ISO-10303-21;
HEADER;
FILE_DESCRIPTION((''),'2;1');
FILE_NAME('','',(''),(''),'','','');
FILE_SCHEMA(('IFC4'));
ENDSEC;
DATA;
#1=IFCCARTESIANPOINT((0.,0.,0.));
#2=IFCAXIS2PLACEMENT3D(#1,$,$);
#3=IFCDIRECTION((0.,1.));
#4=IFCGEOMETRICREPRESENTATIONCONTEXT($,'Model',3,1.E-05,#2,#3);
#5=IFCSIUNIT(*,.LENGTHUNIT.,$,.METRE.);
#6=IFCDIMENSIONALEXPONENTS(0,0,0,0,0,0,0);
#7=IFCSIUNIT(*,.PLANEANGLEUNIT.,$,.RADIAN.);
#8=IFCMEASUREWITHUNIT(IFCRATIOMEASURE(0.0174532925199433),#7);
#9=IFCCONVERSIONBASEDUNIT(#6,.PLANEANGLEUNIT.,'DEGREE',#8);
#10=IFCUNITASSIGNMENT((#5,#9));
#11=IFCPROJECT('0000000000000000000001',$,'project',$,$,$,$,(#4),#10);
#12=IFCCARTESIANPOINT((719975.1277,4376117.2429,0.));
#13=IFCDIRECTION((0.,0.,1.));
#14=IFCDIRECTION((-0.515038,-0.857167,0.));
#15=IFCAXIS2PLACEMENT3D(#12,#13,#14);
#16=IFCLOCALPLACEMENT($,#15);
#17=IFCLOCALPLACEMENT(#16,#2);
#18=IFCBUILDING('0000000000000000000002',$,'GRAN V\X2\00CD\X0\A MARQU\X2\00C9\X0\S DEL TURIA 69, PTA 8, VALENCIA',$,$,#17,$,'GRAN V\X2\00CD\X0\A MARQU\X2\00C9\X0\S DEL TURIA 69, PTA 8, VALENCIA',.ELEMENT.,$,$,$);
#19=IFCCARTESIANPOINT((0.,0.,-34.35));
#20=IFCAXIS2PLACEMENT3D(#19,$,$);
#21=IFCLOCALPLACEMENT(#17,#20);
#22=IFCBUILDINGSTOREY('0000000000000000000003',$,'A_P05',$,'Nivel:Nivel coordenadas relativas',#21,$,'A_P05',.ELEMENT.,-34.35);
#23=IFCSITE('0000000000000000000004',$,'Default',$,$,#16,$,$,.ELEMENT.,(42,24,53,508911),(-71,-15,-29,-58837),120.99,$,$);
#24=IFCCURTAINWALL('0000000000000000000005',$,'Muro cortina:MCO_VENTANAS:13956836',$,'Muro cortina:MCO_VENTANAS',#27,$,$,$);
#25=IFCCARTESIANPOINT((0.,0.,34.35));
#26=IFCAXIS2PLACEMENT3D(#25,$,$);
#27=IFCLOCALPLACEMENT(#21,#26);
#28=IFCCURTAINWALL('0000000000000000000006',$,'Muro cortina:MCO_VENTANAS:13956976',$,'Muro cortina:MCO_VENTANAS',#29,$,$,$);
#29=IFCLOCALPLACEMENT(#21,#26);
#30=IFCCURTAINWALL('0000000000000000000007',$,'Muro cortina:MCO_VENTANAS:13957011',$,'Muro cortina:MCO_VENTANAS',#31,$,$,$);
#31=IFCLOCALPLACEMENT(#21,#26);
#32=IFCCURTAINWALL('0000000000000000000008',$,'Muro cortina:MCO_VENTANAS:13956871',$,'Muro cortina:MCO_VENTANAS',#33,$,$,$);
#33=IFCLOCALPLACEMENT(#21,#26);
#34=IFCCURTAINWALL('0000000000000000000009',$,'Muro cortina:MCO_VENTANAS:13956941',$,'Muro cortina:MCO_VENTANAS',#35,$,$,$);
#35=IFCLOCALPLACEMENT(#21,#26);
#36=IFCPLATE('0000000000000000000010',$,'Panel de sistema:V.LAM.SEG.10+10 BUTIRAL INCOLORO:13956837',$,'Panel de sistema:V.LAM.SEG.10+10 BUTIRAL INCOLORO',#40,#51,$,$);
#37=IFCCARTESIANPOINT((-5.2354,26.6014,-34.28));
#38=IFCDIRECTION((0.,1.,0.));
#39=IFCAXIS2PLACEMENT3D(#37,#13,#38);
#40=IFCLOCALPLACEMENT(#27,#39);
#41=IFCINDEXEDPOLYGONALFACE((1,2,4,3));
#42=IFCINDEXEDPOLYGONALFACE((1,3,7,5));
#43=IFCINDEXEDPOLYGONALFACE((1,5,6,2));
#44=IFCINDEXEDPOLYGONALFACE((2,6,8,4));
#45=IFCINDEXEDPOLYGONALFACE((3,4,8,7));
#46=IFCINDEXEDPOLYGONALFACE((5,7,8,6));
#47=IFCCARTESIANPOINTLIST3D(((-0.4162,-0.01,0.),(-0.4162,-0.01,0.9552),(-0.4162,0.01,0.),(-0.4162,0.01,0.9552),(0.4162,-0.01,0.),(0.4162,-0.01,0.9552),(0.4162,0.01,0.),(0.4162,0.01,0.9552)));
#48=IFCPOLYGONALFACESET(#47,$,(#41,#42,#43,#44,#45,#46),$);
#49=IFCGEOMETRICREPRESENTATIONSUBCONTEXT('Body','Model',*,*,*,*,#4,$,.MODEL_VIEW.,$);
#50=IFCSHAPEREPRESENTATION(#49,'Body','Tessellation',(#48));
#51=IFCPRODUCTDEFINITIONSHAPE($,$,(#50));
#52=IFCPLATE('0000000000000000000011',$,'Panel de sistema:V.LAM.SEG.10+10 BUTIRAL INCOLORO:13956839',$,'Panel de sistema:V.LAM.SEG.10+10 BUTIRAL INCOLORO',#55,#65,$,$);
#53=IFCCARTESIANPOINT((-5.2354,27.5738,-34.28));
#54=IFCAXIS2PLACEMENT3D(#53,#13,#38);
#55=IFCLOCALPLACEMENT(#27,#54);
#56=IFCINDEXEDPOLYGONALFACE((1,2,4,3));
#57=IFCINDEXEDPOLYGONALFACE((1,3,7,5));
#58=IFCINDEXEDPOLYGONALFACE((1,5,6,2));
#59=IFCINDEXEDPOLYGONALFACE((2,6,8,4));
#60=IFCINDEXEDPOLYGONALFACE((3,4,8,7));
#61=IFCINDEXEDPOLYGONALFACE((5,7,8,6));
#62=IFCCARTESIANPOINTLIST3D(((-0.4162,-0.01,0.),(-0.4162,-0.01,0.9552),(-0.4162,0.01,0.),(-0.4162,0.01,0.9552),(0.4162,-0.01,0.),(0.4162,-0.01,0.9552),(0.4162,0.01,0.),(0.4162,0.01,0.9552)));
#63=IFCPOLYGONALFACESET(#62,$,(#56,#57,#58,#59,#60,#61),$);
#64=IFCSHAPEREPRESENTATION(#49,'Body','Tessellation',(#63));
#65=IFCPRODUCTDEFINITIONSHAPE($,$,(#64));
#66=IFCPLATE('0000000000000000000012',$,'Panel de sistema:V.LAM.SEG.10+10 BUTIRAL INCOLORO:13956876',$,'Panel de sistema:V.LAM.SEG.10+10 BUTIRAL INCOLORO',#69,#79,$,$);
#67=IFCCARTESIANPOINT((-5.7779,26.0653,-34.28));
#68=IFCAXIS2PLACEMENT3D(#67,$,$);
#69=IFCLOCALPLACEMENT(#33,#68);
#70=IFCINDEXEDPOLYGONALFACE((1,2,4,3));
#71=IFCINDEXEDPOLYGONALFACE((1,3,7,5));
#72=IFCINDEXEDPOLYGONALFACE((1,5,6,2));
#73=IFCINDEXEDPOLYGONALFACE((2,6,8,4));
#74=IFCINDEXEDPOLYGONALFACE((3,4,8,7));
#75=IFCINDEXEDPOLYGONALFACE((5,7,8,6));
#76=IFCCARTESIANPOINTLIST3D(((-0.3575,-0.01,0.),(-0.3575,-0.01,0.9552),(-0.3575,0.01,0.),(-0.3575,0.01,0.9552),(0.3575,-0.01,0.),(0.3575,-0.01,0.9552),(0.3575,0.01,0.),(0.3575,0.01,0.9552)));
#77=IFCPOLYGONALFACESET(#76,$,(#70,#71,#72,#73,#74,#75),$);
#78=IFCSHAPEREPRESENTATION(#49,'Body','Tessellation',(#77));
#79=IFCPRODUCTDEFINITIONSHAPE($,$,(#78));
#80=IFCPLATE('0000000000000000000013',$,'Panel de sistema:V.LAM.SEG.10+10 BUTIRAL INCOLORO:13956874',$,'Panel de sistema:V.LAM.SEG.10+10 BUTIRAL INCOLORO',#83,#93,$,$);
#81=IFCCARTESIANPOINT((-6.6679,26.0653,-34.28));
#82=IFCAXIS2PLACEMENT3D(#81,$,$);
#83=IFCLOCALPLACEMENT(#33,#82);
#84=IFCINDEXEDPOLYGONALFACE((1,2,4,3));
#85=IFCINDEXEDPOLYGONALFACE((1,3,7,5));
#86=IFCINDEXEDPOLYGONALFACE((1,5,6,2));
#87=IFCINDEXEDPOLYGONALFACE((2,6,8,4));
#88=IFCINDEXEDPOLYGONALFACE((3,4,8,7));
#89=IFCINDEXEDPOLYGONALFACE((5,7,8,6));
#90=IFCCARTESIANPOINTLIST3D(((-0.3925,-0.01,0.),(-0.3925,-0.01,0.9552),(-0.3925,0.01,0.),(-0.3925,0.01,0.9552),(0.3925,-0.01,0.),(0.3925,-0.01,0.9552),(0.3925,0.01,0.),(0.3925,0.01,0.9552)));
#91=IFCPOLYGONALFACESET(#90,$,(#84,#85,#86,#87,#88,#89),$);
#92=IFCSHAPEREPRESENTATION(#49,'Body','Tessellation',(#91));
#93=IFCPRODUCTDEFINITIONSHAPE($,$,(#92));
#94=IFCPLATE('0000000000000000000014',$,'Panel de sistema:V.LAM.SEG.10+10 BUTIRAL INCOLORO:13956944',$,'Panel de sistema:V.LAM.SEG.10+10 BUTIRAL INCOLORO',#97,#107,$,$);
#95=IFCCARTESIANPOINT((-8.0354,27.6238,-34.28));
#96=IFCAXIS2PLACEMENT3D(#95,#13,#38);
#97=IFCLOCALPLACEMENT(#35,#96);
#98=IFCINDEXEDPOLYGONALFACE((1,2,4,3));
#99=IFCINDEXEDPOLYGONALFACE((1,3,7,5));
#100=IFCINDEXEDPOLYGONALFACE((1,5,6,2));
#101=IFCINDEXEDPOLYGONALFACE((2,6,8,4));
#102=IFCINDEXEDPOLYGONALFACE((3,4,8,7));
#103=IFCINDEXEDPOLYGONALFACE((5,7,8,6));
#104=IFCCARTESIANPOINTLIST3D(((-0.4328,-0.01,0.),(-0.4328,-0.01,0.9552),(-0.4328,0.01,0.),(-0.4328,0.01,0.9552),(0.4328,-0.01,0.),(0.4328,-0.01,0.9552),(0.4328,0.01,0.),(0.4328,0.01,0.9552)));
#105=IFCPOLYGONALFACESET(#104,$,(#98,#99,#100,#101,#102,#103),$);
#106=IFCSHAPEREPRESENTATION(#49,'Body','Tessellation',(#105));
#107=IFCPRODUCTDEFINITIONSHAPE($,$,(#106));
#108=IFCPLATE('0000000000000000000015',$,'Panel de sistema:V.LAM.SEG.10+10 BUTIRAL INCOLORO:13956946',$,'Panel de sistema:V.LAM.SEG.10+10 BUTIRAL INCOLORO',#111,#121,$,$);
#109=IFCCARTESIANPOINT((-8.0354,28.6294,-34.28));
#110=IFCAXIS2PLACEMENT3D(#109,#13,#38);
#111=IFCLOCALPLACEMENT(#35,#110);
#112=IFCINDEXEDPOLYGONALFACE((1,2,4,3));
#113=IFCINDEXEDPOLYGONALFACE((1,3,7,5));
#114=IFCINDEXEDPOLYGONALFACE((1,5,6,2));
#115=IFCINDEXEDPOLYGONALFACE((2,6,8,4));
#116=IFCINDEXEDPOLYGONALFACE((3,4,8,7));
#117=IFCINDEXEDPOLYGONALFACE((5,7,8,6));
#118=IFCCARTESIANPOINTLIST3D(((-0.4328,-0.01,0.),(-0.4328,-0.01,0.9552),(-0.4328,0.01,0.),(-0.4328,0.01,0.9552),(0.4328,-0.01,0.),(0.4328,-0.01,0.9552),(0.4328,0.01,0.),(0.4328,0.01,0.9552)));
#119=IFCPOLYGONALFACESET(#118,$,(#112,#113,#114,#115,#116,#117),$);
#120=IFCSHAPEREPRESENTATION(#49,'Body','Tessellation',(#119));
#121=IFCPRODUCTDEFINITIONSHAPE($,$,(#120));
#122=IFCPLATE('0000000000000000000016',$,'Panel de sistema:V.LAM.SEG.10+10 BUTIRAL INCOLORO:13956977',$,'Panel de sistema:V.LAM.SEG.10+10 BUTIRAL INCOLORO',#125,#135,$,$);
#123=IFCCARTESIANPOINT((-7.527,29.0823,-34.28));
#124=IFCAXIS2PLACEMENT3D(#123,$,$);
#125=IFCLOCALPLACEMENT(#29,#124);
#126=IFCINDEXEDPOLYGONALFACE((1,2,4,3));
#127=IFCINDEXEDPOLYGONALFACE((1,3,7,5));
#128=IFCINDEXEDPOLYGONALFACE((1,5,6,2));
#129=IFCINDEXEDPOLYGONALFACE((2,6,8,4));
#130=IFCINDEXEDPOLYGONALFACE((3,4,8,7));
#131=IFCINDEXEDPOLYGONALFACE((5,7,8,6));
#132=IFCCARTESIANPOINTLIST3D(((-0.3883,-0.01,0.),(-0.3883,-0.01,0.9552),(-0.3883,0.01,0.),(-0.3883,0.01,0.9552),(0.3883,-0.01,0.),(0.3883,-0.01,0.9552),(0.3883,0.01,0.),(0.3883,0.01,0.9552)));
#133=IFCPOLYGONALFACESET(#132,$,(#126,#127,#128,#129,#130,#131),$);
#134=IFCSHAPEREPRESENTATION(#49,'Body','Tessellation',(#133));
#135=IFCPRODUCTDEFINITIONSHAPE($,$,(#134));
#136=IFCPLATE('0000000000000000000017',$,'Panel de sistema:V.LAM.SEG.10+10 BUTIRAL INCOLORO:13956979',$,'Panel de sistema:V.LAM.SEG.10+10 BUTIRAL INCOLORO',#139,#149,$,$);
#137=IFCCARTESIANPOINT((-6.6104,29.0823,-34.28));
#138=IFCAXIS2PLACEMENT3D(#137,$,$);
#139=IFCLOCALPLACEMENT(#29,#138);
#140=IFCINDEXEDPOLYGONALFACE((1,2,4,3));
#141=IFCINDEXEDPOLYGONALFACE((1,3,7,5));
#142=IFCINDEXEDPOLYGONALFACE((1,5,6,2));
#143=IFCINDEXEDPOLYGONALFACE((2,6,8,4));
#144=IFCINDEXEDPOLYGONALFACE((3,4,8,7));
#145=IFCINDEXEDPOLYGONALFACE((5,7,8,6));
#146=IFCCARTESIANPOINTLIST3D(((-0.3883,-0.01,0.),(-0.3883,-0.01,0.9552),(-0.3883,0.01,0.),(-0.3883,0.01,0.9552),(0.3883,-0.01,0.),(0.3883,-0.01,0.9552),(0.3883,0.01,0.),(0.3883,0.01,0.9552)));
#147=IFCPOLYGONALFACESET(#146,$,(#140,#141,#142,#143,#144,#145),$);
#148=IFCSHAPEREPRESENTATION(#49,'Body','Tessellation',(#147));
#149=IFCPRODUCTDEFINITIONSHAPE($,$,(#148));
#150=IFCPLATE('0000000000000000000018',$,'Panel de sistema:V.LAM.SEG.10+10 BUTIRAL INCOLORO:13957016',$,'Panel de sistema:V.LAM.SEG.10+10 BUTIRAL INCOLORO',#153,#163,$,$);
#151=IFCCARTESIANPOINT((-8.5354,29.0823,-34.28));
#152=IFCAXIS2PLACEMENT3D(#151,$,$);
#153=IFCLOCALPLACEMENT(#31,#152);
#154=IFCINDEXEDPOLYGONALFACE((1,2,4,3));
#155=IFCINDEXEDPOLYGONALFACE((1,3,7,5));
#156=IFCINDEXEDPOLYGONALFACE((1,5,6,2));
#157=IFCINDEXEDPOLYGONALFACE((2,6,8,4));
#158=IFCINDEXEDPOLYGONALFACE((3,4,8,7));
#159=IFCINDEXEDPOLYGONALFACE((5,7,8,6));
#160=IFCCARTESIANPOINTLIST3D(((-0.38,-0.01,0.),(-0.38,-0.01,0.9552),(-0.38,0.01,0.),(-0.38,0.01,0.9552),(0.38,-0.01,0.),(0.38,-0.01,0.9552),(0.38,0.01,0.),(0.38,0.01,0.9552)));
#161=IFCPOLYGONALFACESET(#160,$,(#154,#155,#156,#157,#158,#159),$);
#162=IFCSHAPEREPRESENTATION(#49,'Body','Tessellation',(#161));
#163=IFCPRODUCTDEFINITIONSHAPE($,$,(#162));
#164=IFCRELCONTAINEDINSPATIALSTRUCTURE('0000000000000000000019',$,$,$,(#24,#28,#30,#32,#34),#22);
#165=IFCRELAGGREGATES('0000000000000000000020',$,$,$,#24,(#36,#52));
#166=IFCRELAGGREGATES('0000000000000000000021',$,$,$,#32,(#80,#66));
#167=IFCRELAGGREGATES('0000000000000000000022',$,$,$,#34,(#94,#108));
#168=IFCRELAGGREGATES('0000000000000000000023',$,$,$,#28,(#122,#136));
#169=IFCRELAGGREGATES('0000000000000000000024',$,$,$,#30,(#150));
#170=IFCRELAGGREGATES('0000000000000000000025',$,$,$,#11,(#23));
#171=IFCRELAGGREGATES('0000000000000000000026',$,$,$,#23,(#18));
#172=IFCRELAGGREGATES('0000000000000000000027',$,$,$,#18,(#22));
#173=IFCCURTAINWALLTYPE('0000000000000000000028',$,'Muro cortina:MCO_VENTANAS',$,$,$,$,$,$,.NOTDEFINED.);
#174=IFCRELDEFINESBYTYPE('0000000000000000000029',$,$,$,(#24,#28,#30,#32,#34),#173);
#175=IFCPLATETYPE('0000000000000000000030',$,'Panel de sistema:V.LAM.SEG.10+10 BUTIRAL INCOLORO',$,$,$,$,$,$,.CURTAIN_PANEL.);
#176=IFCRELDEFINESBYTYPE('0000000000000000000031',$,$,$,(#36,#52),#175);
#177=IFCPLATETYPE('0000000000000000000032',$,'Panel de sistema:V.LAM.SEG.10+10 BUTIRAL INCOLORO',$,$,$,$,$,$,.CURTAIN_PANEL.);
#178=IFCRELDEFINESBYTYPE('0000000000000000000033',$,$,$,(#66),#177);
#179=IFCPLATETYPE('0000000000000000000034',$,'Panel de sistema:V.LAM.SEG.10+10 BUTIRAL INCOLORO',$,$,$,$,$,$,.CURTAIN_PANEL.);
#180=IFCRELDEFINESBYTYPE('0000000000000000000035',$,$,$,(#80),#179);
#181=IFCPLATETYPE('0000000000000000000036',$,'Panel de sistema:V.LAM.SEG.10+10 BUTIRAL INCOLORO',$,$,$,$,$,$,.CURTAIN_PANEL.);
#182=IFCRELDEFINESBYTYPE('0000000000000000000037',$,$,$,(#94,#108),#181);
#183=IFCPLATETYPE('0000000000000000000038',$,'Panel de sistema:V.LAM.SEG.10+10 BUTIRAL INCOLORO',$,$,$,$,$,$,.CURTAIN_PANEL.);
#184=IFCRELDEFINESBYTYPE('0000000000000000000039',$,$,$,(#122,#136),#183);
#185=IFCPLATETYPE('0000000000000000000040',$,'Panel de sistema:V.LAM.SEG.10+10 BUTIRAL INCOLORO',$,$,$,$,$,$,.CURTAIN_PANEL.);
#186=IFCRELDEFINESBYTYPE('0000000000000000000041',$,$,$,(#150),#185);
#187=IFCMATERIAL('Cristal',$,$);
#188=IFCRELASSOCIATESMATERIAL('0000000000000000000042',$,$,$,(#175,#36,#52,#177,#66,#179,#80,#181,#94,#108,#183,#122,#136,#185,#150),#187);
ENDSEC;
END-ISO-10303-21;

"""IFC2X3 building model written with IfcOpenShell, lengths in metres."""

from ifc_helpers import new_model, entity, si_unit, converted_unit, direction, frame, origin, origin_2d_with_axis, place, context, subcontext, project, spatial, rectangle, extrude, source, transform, mapped, material, type_object, type_shapes, element, aggregate, save


model = new_model("IFC2X3")

# Units and contexts
model_context = context("Model", 3, precision=1e-05, world=origin(), true_north=direction((0.0, 1.0)))
body_context = subcontext(model_context, "Body", "Model", "MODEL_VIEW")
ifc_project = project(units=[si_unit("LENGTHUNIT", "METRE"), converted_unit("PLANEANGLEUNIT", "DEGREE", entity("IfcRatioMeasure", 0.0174532925199433), si_unit("PLANEANGLEUNIT", "RADIAN"), dimensions=[0, 0, 0, 0, 0, 0, 0])], contexts=[model_context])

# Site, building, storey
site_placement = place(None, frame((719975.1277, 4376117.2429, 0.0), z_axis=(0.0, 0.0, 1.0), x_axis=(-0.515038, -0.857167, 0.0)))
site = spatial("IfcSite", under=ifc_project, at=site_placement, Name="Default", CompositionType="ELEMENT", RefLatitude=(42, 24, 53, 508911), RefLongitude=(-71, -15, -29, -58837), RefElevation=120.99)
building_placement = place(site_placement, origin())
building = spatial("IfcBuilding", under=site, at=building_placement, Name="GRAN VÍA MARQUÉS DEL TURIA 69, PTA 8, VALENCIA", LongName="GRAN VÍA MARQUÉS DEL TURIA 69, PTA 8, VALENCIA", CompositionType="ELEMENT")
storey_placement = place(building_placement, frame((0.0, 0.0, -34.35)))
storey = spatial("IfcBuildingStorey", under=building, at=storey_placement, Name="A_P05", ObjectType="Nivel:Nivel coordenadas relativas", LongName="A_P05", CompositionType="ELEMENT", Elevation=-34.35)

# Curtain wall
curtain_wall_type = type_object("IfcCurtainWallType", Name="Muro cortina:MCO_VENTANAS", PredefinedType="NOTDEFINED")
curtain_wall_1_placement = place(storey_placement, frame((0.0, 0.0, 34.35)))
curtain_wall_1 = element("IfcCurtainWall", 1, at=curtain_wall_1_placement, inside=storey, type_object=curtain_wall_type, Name="Muro cortina:MCO_VENTANAS:13956836", ObjectType="Muro cortina:MCO_VENTANAS")

# Curtain wall
curtain_wall_2_placement = place(storey_placement, frame((0.0, 0.0, 34.35)))
curtain_wall_2 = element("IfcCurtainWall", 2, at=curtain_wall_2_placement, inside=storey, type_object=curtain_wall_type, Name="Muro cortina:MCO_VENTANAS:13956976", ObjectType="Muro cortina:MCO_VENTANAS")

# Curtain walls
curtain_wall_3_placement = place(storey_placement, frame((0.0, 0.0, 34.35)))
curtain_wall_3 = element("IfcCurtainWall", 3, at=curtain_wall_3_placement, inside=storey, type_object=curtain_wall_type, Name="Muro cortina:MCO_VENTANAS:13957011", ObjectType="Muro cortina:MCO_VENTANAS")
curtain_wall_4_placement = place(storey_placement, frame((0.0, 0.0, 34.35)))
curtain_wall_4 = element("IfcCurtainWall", 4, at=curtain_wall_4_placement, inside=storey, type_object=curtain_wall_type, Name="Muro cortina:MCO_VENTANAS:13956871", ObjectType="Muro cortina:MCO_VENTANAS")
curtain_wall_5_placement = place(storey_placement, frame((0.0, 0.0, 34.35)))
curtain_wall_5 = element("IfcCurtainWall", 5, at=curtain_wall_5_placement, inside=storey, type_object=curtain_wall_type, Name="Muro cortina:MCO_VENTANAS:13956941", ObjectType="Muro cortina:MCO_VENTANAS")

# Plates
ifc_material_1 = material(Name="Cristal")
plate_type_1 = type_object("IfcPlateType", Name="Panel de sistema:V.LAM.SEG.10+10 BUTIRAL INCOLORO", PredefinedType="CURTAIN_PANEL", material=ifc_material_1)
shared_shape_1 = source(origin(), body_context, "Body", "SweptSolid", [
    extrude(rectangle(XDim=0.02, YDim=0.8323, at=origin_2d_with_axis()), frame((0.0, 0.0, 0.0), z_axis=(0.0, 0.0, 1.0), x_axis=(0.0, 1.0, 0.0)), (0.0, 0.0, 1.0), 0.9552),
])
type_shapes(plate_type_1, [shared_shape_1])
plate_1_placement = place(curtain_wall_1_placement, frame((-5.2354, 26.6014, -34.28), z_axis=(0.0, 0.0, 1.0), x_axis=(0.0, 1.0, 0.0)))
plate_1 = element("IfcPlate", 6, at=plate_1_placement, type_object=plate_type_1, material=ifc_material_1, Name="Panel de sistema:V.LAM.SEG.10+10 BUTIRAL INCOLORO:13956837", ObjectType="Panel de sistema:V.LAM.SEG.10+10 BUTIRAL INCOLORO", context=body_context, shape_type="MappedRepresentation", body=[
    mapped(shared_shape_1, transform((0.0, 0.0, 0.0), scale=1.0)),
])
plate_2_placement = place(curtain_wall_1_placement, frame((-5.2354, 27.5738, -34.28), z_axis=(0.0, 0.0, 1.0), x_axis=(0.0, 1.0, 0.0)))
plate_2 = element("IfcPlate", 7, at=plate_2_placement, type_object=plate_type_1, material=ifc_material_1, Name="Panel de sistema:V.LAM.SEG.10+10 BUTIRAL INCOLORO:13956839", ObjectType="Panel de sistema:V.LAM.SEG.10+10 BUTIRAL INCOLORO", context=body_context, shape_type="MappedRepresentation", body=[
    mapped(shared_shape_1, transform((0.0, 0.0, 0.0), scale=1.0)),
])
aggregate(curtain_wall_1, [plate_1, plate_2])
plate_type_2 = type_object("IfcPlateType", Name="Panel de sistema:V.LAM.SEG.10+10 BUTIRAL INCOLORO", PredefinedType="CURTAIN_PANEL", material=ifc_material_1)
shared_shape_2 = source(origin(), body_context, "Body", "SweptSolid", [
    extrude(rectangle(XDim=0.02, YDim=0.715, at=origin_2d_with_axis()), frame((0.0, 0.0, 0.0), z_axis=(0.0, 0.0, 1.0), x_axis=(0.0, 1.0, 0.0)), (0.0, 0.0, 1.0), 0.9552),
])
type_shapes(plate_type_2, [shared_shape_2])
plate_3_placement = place(curtain_wall_4_placement, frame((-5.7779, 26.0653, -34.28)))
plate_3 = element("IfcPlate", 8, at=plate_3_placement, type_object=plate_type_2, material=ifc_material_1, Name="Panel de sistema:V.LAM.SEG.10+10 BUTIRAL INCOLORO:13956876", ObjectType="Panel de sistema:V.LAM.SEG.10+10 BUTIRAL INCOLORO", context=body_context, shape_type="MappedRepresentation", body=[
    mapped(shared_shape_2, transform((0.0, 0.0, 0.0), scale=1.0)),
])
plate_type_3 = type_object("IfcPlateType", Name="Panel de sistema:V.LAM.SEG.10+10 BUTIRAL INCOLORO", PredefinedType="CURTAIN_PANEL", material=ifc_material_1)
shared_shape_3 = source(origin(), body_context, "Body", "SweptSolid", [
    extrude(rectangle(XDim=0.02, YDim=0.785, at=origin_2d_with_axis()), frame((0.0, 0.0, 0.0), z_axis=(0.0, 0.0, 1.0), x_axis=(0.0, 1.0, 0.0)), (0.0, 0.0, 1.0), 0.9552),
])
type_shapes(plate_type_3, [shared_shape_3])
plate_4_placement = place(curtain_wall_4_placement, frame((-6.6679, 26.0653, -34.28)))
plate_4 = element("IfcPlate", 9, at=plate_4_placement, type_object=plate_type_3, material=ifc_material_1, Name="Panel de sistema:V.LAM.SEG.10+10 BUTIRAL INCOLORO:13956874", ObjectType="Panel de sistema:V.LAM.SEG.10+10 BUTIRAL INCOLORO", context=body_context, shape_type="MappedRepresentation", body=[
    mapped(shared_shape_3, transform((0.0, 0.0, 0.0), scale=1.0)),
])
aggregate(curtain_wall_4, [plate_4, plate_3])
plate_type_4 = type_object("IfcPlateType", Name="Panel de sistema:V.LAM.SEG.10+10 BUTIRAL INCOLORO", PredefinedType="CURTAIN_PANEL", material=ifc_material_1)
shared_shape_4 = source(origin(), body_context, "Body", "SweptSolid", [
    extrude(rectangle(XDim=0.02, YDim=0.8657, at=origin_2d_with_axis()), frame((0.0, 0.0, 0.0), z_axis=(0.0, 0.0, 1.0), x_axis=(0.0, 1.0, 0.0)), (0.0, 0.0, 1.0), 0.9552),
])
type_shapes(plate_type_4, [shared_shape_4])
plate_5_placement = place(curtain_wall_5_placement, frame((-8.0354, 27.6238, -34.28), z_axis=(0.0, 0.0, 1.0), x_axis=(0.0, 1.0, 0.0)))
plate_5 = element("IfcPlate", 10, at=plate_5_placement, type_object=plate_type_4, material=ifc_material_1, Name="Panel de sistema:V.LAM.SEG.10+10 BUTIRAL INCOLORO:13956944", ObjectType="Panel de sistema:V.LAM.SEG.10+10 BUTIRAL INCOLORO", context=body_context, shape_type="MappedRepresentation", body=[
    mapped(shared_shape_4, transform((0.0, 0.0, 0.0), scale=1.0)),
])
plate_6_placement = place(curtain_wall_5_placement, frame((-8.0354, 28.6294, -34.28), z_axis=(0.0, 0.0, 1.0), x_axis=(0.0, 1.0, 0.0)))
plate_6 = element("IfcPlate", 11, at=plate_6_placement, type_object=plate_type_4, material=ifc_material_1, Name="Panel de sistema:V.LAM.SEG.10+10 BUTIRAL INCOLORO:13956946", ObjectType="Panel de sistema:V.LAM.SEG.10+10 BUTIRAL INCOLORO", context=body_context, shape_type="MappedRepresentation", body=[
    mapped(shared_shape_4, transform((0.0, 0.0, 0.0), scale=1.0)),
])
aggregate(curtain_wall_5, [plate_5, plate_6])
plate_type_5 = type_object("IfcPlateType", Name="Panel de sistema:V.LAM.SEG.10+10 BUTIRAL INCOLORO", PredefinedType="CURTAIN_PANEL", material=ifc_material_1)
shared_shape_5 = source(origin(), body_context, "Body", "SweptSolid", [
    extrude(rectangle(XDim=0.02, YDim=0.7767, at=origin_2d_with_axis()), frame((0.0, 0.0, 0.0), z_axis=(0.0, 0.0, 1.0), x_axis=(0.0, 1.0, 0.0)), (0.0, 0.0, 1.0), 0.9552),
])
type_shapes(plate_type_5, [shared_shape_5])
plate_7_placement = place(curtain_wall_2_placement, frame((-7.527, 29.0823, -34.28)))
plate_7 = element("IfcPlate", 12, at=plate_7_placement, type_object=plate_type_5, material=ifc_material_1, Name="Panel de sistema:V.LAM.SEG.10+10 BUTIRAL INCOLORO:13956977", ObjectType="Panel de sistema:V.LAM.SEG.10+10 BUTIRAL INCOLORO", context=body_context, shape_type="MappedRepresentation", body=[
    mapped(shared_shape_5, transform((0.0, 0.0, 0.0), scale=1.0)),
])
plate_8_placement = place(curtain_wall_2_placement, frame((-6.6104, 29.0823, -34.28)))
plate_8 = element("IfcPlate", 13, at=plate_8_placement, type_object=plate_type_5, material=ifc_material_1, Name="Panel de sistema:V.LAM.SEG.10+10 BUTIRAL INCOLORO:13956979", ObjectType="Panel de sistema:V.LAM.SEG.10+10 BUTIRAL INCOLORO", context=body_context, shape_type="MappedRepresentation", body=[
    mapped(shared_shape_5, transform((0.0, 0.0, 0.0), scale=1.0)),
])
aggregate(curtain_wall_2, [plate_7, plate_8])
plate_type_6 = type_object("IfcPlateType", Name="Panel de sistema:V.LAM.SEG.10+10 BUTIRAL INCOLORO", PredefinedType="CURTAIN_PANEL", material=ifc_material_1)
shared_shape_6 = source(origin(), body_context, "Body", "SweptSolid", [
    extrude(rectangle(XDim=0.02, YDim=0.76, at=origin_2d_with_axis()), frame((0.0, 0.0, 0.0), z_axis=(0.0, 0.0, 1.0), x_axis=(0.0, 1.0, 0.0)), (0.0, 0.0, 1.0), 0.9552),
])
type_shapes(plate_type_6, [shared_shape_6])
plate_9_placement = place(curtain_wall_3_placement, frame((-8.5354, 29.0823, -34.28)))
plate_9 = element("IfcPlate", 14, at=plate_9_placement, type_object=plate_type_6, material=ifc_material_1, Name="Panel de sistema:V.LAM.SEG.10+10 BUTIRAL INCOLORO:13957016", ObjectType="Panel de sistema:V.LAM.SEG.10+10 BUTIRAL INCOLORO", context=body_context, shape_type="MappedRepresentation", body=[
    mapped(shared_shape_6, transform((0.0, 0.0, 0.0), scale=1.0)),
])
aggregate(curtain_wall_3, [plate_9])

save(model, "model.ifc")
